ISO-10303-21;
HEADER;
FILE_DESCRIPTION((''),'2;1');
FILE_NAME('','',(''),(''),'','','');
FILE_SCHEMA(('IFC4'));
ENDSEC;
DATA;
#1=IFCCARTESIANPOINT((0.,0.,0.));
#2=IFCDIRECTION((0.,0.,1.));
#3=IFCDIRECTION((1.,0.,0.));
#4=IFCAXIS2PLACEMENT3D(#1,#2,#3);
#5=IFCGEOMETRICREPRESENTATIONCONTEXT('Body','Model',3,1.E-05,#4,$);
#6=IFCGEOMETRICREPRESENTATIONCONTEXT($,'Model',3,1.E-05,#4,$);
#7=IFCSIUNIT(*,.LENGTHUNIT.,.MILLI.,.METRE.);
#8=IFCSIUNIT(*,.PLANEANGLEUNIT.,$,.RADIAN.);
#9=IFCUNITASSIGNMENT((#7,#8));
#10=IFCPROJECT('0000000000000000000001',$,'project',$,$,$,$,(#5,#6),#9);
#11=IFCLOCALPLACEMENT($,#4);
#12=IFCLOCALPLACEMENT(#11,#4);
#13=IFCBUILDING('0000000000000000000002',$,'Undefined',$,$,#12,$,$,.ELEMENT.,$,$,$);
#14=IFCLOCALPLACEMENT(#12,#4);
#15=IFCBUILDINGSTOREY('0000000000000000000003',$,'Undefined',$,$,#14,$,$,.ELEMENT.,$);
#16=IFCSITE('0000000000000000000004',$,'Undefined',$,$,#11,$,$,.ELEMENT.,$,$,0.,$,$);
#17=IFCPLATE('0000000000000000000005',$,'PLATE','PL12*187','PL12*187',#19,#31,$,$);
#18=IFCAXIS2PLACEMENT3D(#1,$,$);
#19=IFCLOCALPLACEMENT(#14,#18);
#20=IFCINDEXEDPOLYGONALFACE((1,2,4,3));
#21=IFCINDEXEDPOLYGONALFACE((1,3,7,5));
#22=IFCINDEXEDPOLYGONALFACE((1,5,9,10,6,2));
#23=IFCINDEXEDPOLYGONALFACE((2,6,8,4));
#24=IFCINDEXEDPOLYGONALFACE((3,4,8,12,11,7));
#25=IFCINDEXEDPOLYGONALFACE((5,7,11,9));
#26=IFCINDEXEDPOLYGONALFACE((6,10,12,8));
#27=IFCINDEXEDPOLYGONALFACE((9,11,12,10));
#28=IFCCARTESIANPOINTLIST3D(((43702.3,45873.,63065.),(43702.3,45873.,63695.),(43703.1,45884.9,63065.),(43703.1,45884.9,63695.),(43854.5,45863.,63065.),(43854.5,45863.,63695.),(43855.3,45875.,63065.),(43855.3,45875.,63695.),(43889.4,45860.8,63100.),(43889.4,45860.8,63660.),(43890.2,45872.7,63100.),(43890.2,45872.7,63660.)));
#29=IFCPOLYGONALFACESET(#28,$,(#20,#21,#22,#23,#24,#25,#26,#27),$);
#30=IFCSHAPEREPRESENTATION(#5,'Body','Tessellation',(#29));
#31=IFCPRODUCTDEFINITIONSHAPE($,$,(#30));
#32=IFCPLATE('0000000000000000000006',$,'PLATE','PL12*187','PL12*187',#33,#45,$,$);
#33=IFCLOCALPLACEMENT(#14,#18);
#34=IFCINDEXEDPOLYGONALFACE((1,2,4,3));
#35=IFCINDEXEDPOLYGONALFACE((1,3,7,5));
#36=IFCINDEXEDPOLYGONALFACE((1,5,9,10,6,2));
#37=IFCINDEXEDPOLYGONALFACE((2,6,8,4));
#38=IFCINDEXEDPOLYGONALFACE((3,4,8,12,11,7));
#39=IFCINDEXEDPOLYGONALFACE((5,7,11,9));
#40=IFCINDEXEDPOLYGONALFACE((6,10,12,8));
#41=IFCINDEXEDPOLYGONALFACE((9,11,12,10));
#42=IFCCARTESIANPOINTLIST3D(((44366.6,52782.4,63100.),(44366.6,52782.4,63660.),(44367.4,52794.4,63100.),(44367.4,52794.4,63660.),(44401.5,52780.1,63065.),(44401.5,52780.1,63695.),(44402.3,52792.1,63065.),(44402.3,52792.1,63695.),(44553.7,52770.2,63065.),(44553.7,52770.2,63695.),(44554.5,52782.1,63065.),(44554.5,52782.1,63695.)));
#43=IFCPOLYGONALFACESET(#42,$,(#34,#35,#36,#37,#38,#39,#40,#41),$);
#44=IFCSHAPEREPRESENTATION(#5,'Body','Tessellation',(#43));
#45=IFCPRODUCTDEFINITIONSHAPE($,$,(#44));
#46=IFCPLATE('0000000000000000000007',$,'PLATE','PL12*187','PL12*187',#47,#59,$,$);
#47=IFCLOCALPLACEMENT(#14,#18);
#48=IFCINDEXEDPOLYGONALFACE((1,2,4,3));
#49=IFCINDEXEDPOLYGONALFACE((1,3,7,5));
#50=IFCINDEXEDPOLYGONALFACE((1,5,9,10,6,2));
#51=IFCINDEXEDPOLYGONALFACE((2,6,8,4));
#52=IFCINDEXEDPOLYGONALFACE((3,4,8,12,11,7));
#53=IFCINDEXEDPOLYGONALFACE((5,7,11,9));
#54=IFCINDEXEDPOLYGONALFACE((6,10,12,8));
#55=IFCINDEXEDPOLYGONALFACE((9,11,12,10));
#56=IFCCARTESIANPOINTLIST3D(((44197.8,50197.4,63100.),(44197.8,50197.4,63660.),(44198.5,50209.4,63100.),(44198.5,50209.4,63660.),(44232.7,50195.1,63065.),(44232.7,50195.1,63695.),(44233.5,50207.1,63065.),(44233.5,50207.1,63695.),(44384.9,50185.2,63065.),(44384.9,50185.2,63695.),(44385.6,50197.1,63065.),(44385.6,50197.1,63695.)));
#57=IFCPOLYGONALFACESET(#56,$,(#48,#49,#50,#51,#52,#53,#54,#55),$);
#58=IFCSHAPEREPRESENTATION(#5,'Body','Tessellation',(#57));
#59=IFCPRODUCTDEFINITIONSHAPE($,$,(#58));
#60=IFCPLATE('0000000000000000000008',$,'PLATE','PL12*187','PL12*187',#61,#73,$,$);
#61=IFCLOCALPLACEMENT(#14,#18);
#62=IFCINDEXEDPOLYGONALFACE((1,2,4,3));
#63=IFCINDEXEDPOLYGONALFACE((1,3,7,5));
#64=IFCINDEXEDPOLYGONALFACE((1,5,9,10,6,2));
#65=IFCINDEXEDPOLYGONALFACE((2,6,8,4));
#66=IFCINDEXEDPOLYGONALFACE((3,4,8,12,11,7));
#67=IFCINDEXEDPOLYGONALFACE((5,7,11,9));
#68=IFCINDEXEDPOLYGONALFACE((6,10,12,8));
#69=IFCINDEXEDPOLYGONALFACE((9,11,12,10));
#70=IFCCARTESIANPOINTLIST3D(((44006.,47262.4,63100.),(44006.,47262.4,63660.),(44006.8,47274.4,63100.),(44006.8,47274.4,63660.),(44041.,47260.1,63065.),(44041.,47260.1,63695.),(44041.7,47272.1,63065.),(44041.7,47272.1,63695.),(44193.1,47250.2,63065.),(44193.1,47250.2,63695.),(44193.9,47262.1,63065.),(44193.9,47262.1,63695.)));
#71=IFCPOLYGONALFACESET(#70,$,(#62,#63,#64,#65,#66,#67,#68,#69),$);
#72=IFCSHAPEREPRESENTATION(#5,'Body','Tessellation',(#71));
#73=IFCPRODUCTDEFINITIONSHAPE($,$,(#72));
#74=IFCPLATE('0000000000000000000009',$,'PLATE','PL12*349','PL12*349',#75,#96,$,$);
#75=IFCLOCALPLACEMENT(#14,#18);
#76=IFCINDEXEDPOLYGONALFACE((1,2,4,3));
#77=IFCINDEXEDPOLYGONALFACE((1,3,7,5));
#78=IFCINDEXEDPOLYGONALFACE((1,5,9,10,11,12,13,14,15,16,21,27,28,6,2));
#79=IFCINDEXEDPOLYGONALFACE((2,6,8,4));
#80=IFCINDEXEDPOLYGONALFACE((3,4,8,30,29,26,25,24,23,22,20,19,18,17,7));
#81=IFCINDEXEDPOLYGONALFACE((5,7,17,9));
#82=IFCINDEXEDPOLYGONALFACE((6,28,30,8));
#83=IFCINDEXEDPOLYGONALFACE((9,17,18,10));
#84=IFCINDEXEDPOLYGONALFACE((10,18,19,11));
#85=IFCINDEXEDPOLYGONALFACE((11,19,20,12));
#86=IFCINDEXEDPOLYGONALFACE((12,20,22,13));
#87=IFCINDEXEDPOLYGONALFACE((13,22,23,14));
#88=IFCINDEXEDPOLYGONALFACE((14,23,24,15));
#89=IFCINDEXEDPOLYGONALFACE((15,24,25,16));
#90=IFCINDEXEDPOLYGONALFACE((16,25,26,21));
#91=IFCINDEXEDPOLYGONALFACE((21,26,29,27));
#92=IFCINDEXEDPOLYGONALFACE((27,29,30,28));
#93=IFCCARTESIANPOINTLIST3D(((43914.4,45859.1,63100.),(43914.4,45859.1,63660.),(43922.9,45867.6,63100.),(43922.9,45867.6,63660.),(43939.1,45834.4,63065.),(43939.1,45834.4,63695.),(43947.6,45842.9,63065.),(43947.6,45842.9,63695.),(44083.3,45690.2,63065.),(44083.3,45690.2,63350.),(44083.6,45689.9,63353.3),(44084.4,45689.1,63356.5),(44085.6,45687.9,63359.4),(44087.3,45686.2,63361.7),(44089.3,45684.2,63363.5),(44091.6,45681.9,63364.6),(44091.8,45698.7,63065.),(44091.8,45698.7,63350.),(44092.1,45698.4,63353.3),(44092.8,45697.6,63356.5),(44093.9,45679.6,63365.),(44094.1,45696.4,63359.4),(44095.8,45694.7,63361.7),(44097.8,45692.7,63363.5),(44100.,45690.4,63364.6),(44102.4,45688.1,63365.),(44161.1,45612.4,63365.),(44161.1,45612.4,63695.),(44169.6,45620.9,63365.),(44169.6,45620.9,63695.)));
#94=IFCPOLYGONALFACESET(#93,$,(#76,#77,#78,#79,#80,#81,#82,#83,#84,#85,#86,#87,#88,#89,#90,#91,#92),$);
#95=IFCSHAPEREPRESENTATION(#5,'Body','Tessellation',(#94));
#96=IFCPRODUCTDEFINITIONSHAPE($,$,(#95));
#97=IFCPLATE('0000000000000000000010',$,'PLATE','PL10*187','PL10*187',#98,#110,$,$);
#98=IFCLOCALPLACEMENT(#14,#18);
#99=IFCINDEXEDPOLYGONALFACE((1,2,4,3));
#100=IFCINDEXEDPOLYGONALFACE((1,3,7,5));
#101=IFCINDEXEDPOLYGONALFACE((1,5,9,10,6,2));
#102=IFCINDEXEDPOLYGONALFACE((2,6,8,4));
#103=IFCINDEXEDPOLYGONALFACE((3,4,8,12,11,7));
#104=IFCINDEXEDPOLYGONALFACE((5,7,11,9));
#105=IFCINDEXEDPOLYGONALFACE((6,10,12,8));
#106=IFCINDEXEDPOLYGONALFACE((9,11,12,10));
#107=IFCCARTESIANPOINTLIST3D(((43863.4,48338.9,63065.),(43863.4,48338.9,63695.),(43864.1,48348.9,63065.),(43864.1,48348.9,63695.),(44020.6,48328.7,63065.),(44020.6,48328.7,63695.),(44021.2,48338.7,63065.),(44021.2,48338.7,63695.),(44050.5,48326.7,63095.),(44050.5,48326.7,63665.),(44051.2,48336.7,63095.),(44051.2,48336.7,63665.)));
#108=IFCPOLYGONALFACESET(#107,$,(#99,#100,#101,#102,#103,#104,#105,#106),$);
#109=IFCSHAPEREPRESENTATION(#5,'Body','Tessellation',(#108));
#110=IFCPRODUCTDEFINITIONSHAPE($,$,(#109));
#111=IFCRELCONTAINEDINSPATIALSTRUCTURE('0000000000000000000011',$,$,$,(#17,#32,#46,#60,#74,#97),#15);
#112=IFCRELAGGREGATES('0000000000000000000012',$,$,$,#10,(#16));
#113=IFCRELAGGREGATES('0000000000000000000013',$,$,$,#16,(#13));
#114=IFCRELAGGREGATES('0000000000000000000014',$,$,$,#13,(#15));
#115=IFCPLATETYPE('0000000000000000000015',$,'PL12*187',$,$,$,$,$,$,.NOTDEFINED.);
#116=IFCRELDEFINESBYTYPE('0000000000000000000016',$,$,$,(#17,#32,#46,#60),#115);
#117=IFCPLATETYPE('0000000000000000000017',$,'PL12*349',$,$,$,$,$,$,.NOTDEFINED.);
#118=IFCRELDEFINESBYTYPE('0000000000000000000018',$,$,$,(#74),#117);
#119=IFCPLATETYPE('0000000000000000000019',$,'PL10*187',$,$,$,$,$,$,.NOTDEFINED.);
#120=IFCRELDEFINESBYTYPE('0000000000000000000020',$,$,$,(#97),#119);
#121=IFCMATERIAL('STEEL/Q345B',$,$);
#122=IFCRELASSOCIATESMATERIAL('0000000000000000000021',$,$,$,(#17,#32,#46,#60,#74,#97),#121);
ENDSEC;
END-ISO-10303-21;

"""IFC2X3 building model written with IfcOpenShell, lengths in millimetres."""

from ifc_helpers import new_model, si_unit, frame, origin_with_axes, place, context, project, spatial, polyline, outline, extrude, material, type_object, element, save


model = new_model("IFC2X3")

# Units and contexts
model_context_1 = context("Model", 3, precision=1e-05, world=origin_with_axes(), identifier="Body")
model_context_2 = context("Model", 3, precision=1e-05, world=origin_with_axes())
ifc_project = project(units=[si_unit("LENGTHUNIT", "METRE", prefix="MILLI"), si_unit("PLANEANGLEUNIT", "RADIAN")], contexts=[model_context_1, model_context_2])

# Site, building, storey
site_placement = place(None, origin_with_axes())
site = spatial("IfcSite", under=ifc_project, at=site_placement, Name="Undefined", CompositionType="ELEMENT", RefElevation=0.0)
building_placement = place(site_placement, origin_with_axes())
building = spatial("IfcBuilding", under=site, at=building_placement, Name="Undefined", CompositionType="ELEMENT")
storey_placement = place(building_placement, origin_with_axes())
storey = spatial("IfcBuildingStorey", under=building, at=storey_placement, Name="Undefined", CompositionType="ELEMENT")

# Shared definitions
ifc_material_1 = material(Name="STEEL/Q345B")

# Plates
plate_type_1 = type_object("IfcPlateType", Name="PL12*187", PredefinedType="NOTDEFINED")
for number, where, z_axis, x_axis, name in (
    (1, (43889.8, 45866.7, 63065.0), (0.065184, 0.997873, 0.0), (-0.997873, 0.065184, 0.0), "PLATE"),
    (2, (44367.0, 52788.4, 63065.0), (-0.065183, -0.997873, 0.0), (0.997873, -0.065183, 0.0), "PLATE"),
    (3, (44198.1, 50203.4, 63065.0), (-0.065183, -0.997873, 0.0), (0.997873, -0.065183, 0.0), "PLATE"),
    (4, (44006.4, 47268.4, 63065.0), (-0.065183, -0.997873, 0.0), (0.997873, -0.065183, 0.0), "PLATE"),
):
    element("IfcPlate", number, at=place(storey_placement, frame(where, z_axis=z_axis, x_axis=x_axis)), inside=storey, type_object=plate_type_1, material=ifc_material_1, Name=name, Description="PL12*187", ObjectType="PL12*187", context=model_context_1, shape_type="SweptSolid", body=[
        extrude(outline(polyline([(0.0, 35.0), (35.0, 0.0), (187.5, 0.0), (187.5, 630.0), (35.0, 630.0), (0.0, 595.0), (0.0, 35.0)])), frame((0.0, 0.0, -6.0), z_axis=(0.0, 0.0, 1.0), x_axis=(1.0, 0.0, 0.0)), (0.0, 0.0, 1.0), 12.0),
    ])
plate_type_2 = type_object("IfcPlateType", Name="PL12*349", PredefinedType="NOTDEFINED")
plate_1_placement = place(storey_placement, frame((44165.4, 45616.6, 63695.0), z_axis=(0.707107, 0.707107, 0.0), x_axis=(0.0, 0.0, -1.0)))
element("IfcPlate", 5, at=plate_1_placement, inside=storey, type_object=plate_type_2, material=ifc_material_1, Name="PLATE", Description="PL12*349", ObjectType="PL12*349", context=model_context_1, shape_type="SweptSolid", body=[
    extrude(outline(polyline([(0.0, 0.0), (330.0, 0.0), (330.0, 95.0), (330.4, 98.4), (331.5, 101.5), (333.3, 104.4), (335.6, 106.8), (338.5, 108.5), (341.7, 109.7), (345.0, 110.0), (630.0, 110.0), (630.0, 313.9), (595.0, 348.9), (35.0, 348.9), (0.0, 313.9), (0.0, 0.0)])), frame((0.0, 0.0, -6.0), z_axis=(0.0, 0.0, 1.0), x_axis=(1.0, 0.0, 0.0)), (0.0, 0.0, 1.0), 12.0),
])
plate_type_3 = type_object("IfcPlateType", Name="PL10*187", PredefinedType="NOTDEFINED")
plate_2_placement = place(storey_placement, frame((44050.8, 48331.7, 63065.0), z_axis=(0.065184, 0.997873, 0.0), x_axis=(-0.997873, 0.065184, 0.0)))
element("IfcPlate", 6, at=plate_2_placement, inside=storey, type_object=plate_type_3, material=ifc_material_1, Name="PLATE", Description="PL10*187", ObjectType="PL10*187", context=model_context_1, shape_type="SweptSolid", body=[
    extrude(outline(polyline([(0.0, 30.0), (30.0, 0.0), (187.5, 0.0), (187.5, 630.0), (30.0, 630.0), (0.0, 600.0), (0.0, 30.0)])), frame((0.0, 0.0, -5.0), z_axis=(0.0, 0.0, 1.0), x_axis=(1.0, 0.0, 0.0)), (0.0, 0.0, 1.0), 10.0),
])

save(model, "model.ifc")
